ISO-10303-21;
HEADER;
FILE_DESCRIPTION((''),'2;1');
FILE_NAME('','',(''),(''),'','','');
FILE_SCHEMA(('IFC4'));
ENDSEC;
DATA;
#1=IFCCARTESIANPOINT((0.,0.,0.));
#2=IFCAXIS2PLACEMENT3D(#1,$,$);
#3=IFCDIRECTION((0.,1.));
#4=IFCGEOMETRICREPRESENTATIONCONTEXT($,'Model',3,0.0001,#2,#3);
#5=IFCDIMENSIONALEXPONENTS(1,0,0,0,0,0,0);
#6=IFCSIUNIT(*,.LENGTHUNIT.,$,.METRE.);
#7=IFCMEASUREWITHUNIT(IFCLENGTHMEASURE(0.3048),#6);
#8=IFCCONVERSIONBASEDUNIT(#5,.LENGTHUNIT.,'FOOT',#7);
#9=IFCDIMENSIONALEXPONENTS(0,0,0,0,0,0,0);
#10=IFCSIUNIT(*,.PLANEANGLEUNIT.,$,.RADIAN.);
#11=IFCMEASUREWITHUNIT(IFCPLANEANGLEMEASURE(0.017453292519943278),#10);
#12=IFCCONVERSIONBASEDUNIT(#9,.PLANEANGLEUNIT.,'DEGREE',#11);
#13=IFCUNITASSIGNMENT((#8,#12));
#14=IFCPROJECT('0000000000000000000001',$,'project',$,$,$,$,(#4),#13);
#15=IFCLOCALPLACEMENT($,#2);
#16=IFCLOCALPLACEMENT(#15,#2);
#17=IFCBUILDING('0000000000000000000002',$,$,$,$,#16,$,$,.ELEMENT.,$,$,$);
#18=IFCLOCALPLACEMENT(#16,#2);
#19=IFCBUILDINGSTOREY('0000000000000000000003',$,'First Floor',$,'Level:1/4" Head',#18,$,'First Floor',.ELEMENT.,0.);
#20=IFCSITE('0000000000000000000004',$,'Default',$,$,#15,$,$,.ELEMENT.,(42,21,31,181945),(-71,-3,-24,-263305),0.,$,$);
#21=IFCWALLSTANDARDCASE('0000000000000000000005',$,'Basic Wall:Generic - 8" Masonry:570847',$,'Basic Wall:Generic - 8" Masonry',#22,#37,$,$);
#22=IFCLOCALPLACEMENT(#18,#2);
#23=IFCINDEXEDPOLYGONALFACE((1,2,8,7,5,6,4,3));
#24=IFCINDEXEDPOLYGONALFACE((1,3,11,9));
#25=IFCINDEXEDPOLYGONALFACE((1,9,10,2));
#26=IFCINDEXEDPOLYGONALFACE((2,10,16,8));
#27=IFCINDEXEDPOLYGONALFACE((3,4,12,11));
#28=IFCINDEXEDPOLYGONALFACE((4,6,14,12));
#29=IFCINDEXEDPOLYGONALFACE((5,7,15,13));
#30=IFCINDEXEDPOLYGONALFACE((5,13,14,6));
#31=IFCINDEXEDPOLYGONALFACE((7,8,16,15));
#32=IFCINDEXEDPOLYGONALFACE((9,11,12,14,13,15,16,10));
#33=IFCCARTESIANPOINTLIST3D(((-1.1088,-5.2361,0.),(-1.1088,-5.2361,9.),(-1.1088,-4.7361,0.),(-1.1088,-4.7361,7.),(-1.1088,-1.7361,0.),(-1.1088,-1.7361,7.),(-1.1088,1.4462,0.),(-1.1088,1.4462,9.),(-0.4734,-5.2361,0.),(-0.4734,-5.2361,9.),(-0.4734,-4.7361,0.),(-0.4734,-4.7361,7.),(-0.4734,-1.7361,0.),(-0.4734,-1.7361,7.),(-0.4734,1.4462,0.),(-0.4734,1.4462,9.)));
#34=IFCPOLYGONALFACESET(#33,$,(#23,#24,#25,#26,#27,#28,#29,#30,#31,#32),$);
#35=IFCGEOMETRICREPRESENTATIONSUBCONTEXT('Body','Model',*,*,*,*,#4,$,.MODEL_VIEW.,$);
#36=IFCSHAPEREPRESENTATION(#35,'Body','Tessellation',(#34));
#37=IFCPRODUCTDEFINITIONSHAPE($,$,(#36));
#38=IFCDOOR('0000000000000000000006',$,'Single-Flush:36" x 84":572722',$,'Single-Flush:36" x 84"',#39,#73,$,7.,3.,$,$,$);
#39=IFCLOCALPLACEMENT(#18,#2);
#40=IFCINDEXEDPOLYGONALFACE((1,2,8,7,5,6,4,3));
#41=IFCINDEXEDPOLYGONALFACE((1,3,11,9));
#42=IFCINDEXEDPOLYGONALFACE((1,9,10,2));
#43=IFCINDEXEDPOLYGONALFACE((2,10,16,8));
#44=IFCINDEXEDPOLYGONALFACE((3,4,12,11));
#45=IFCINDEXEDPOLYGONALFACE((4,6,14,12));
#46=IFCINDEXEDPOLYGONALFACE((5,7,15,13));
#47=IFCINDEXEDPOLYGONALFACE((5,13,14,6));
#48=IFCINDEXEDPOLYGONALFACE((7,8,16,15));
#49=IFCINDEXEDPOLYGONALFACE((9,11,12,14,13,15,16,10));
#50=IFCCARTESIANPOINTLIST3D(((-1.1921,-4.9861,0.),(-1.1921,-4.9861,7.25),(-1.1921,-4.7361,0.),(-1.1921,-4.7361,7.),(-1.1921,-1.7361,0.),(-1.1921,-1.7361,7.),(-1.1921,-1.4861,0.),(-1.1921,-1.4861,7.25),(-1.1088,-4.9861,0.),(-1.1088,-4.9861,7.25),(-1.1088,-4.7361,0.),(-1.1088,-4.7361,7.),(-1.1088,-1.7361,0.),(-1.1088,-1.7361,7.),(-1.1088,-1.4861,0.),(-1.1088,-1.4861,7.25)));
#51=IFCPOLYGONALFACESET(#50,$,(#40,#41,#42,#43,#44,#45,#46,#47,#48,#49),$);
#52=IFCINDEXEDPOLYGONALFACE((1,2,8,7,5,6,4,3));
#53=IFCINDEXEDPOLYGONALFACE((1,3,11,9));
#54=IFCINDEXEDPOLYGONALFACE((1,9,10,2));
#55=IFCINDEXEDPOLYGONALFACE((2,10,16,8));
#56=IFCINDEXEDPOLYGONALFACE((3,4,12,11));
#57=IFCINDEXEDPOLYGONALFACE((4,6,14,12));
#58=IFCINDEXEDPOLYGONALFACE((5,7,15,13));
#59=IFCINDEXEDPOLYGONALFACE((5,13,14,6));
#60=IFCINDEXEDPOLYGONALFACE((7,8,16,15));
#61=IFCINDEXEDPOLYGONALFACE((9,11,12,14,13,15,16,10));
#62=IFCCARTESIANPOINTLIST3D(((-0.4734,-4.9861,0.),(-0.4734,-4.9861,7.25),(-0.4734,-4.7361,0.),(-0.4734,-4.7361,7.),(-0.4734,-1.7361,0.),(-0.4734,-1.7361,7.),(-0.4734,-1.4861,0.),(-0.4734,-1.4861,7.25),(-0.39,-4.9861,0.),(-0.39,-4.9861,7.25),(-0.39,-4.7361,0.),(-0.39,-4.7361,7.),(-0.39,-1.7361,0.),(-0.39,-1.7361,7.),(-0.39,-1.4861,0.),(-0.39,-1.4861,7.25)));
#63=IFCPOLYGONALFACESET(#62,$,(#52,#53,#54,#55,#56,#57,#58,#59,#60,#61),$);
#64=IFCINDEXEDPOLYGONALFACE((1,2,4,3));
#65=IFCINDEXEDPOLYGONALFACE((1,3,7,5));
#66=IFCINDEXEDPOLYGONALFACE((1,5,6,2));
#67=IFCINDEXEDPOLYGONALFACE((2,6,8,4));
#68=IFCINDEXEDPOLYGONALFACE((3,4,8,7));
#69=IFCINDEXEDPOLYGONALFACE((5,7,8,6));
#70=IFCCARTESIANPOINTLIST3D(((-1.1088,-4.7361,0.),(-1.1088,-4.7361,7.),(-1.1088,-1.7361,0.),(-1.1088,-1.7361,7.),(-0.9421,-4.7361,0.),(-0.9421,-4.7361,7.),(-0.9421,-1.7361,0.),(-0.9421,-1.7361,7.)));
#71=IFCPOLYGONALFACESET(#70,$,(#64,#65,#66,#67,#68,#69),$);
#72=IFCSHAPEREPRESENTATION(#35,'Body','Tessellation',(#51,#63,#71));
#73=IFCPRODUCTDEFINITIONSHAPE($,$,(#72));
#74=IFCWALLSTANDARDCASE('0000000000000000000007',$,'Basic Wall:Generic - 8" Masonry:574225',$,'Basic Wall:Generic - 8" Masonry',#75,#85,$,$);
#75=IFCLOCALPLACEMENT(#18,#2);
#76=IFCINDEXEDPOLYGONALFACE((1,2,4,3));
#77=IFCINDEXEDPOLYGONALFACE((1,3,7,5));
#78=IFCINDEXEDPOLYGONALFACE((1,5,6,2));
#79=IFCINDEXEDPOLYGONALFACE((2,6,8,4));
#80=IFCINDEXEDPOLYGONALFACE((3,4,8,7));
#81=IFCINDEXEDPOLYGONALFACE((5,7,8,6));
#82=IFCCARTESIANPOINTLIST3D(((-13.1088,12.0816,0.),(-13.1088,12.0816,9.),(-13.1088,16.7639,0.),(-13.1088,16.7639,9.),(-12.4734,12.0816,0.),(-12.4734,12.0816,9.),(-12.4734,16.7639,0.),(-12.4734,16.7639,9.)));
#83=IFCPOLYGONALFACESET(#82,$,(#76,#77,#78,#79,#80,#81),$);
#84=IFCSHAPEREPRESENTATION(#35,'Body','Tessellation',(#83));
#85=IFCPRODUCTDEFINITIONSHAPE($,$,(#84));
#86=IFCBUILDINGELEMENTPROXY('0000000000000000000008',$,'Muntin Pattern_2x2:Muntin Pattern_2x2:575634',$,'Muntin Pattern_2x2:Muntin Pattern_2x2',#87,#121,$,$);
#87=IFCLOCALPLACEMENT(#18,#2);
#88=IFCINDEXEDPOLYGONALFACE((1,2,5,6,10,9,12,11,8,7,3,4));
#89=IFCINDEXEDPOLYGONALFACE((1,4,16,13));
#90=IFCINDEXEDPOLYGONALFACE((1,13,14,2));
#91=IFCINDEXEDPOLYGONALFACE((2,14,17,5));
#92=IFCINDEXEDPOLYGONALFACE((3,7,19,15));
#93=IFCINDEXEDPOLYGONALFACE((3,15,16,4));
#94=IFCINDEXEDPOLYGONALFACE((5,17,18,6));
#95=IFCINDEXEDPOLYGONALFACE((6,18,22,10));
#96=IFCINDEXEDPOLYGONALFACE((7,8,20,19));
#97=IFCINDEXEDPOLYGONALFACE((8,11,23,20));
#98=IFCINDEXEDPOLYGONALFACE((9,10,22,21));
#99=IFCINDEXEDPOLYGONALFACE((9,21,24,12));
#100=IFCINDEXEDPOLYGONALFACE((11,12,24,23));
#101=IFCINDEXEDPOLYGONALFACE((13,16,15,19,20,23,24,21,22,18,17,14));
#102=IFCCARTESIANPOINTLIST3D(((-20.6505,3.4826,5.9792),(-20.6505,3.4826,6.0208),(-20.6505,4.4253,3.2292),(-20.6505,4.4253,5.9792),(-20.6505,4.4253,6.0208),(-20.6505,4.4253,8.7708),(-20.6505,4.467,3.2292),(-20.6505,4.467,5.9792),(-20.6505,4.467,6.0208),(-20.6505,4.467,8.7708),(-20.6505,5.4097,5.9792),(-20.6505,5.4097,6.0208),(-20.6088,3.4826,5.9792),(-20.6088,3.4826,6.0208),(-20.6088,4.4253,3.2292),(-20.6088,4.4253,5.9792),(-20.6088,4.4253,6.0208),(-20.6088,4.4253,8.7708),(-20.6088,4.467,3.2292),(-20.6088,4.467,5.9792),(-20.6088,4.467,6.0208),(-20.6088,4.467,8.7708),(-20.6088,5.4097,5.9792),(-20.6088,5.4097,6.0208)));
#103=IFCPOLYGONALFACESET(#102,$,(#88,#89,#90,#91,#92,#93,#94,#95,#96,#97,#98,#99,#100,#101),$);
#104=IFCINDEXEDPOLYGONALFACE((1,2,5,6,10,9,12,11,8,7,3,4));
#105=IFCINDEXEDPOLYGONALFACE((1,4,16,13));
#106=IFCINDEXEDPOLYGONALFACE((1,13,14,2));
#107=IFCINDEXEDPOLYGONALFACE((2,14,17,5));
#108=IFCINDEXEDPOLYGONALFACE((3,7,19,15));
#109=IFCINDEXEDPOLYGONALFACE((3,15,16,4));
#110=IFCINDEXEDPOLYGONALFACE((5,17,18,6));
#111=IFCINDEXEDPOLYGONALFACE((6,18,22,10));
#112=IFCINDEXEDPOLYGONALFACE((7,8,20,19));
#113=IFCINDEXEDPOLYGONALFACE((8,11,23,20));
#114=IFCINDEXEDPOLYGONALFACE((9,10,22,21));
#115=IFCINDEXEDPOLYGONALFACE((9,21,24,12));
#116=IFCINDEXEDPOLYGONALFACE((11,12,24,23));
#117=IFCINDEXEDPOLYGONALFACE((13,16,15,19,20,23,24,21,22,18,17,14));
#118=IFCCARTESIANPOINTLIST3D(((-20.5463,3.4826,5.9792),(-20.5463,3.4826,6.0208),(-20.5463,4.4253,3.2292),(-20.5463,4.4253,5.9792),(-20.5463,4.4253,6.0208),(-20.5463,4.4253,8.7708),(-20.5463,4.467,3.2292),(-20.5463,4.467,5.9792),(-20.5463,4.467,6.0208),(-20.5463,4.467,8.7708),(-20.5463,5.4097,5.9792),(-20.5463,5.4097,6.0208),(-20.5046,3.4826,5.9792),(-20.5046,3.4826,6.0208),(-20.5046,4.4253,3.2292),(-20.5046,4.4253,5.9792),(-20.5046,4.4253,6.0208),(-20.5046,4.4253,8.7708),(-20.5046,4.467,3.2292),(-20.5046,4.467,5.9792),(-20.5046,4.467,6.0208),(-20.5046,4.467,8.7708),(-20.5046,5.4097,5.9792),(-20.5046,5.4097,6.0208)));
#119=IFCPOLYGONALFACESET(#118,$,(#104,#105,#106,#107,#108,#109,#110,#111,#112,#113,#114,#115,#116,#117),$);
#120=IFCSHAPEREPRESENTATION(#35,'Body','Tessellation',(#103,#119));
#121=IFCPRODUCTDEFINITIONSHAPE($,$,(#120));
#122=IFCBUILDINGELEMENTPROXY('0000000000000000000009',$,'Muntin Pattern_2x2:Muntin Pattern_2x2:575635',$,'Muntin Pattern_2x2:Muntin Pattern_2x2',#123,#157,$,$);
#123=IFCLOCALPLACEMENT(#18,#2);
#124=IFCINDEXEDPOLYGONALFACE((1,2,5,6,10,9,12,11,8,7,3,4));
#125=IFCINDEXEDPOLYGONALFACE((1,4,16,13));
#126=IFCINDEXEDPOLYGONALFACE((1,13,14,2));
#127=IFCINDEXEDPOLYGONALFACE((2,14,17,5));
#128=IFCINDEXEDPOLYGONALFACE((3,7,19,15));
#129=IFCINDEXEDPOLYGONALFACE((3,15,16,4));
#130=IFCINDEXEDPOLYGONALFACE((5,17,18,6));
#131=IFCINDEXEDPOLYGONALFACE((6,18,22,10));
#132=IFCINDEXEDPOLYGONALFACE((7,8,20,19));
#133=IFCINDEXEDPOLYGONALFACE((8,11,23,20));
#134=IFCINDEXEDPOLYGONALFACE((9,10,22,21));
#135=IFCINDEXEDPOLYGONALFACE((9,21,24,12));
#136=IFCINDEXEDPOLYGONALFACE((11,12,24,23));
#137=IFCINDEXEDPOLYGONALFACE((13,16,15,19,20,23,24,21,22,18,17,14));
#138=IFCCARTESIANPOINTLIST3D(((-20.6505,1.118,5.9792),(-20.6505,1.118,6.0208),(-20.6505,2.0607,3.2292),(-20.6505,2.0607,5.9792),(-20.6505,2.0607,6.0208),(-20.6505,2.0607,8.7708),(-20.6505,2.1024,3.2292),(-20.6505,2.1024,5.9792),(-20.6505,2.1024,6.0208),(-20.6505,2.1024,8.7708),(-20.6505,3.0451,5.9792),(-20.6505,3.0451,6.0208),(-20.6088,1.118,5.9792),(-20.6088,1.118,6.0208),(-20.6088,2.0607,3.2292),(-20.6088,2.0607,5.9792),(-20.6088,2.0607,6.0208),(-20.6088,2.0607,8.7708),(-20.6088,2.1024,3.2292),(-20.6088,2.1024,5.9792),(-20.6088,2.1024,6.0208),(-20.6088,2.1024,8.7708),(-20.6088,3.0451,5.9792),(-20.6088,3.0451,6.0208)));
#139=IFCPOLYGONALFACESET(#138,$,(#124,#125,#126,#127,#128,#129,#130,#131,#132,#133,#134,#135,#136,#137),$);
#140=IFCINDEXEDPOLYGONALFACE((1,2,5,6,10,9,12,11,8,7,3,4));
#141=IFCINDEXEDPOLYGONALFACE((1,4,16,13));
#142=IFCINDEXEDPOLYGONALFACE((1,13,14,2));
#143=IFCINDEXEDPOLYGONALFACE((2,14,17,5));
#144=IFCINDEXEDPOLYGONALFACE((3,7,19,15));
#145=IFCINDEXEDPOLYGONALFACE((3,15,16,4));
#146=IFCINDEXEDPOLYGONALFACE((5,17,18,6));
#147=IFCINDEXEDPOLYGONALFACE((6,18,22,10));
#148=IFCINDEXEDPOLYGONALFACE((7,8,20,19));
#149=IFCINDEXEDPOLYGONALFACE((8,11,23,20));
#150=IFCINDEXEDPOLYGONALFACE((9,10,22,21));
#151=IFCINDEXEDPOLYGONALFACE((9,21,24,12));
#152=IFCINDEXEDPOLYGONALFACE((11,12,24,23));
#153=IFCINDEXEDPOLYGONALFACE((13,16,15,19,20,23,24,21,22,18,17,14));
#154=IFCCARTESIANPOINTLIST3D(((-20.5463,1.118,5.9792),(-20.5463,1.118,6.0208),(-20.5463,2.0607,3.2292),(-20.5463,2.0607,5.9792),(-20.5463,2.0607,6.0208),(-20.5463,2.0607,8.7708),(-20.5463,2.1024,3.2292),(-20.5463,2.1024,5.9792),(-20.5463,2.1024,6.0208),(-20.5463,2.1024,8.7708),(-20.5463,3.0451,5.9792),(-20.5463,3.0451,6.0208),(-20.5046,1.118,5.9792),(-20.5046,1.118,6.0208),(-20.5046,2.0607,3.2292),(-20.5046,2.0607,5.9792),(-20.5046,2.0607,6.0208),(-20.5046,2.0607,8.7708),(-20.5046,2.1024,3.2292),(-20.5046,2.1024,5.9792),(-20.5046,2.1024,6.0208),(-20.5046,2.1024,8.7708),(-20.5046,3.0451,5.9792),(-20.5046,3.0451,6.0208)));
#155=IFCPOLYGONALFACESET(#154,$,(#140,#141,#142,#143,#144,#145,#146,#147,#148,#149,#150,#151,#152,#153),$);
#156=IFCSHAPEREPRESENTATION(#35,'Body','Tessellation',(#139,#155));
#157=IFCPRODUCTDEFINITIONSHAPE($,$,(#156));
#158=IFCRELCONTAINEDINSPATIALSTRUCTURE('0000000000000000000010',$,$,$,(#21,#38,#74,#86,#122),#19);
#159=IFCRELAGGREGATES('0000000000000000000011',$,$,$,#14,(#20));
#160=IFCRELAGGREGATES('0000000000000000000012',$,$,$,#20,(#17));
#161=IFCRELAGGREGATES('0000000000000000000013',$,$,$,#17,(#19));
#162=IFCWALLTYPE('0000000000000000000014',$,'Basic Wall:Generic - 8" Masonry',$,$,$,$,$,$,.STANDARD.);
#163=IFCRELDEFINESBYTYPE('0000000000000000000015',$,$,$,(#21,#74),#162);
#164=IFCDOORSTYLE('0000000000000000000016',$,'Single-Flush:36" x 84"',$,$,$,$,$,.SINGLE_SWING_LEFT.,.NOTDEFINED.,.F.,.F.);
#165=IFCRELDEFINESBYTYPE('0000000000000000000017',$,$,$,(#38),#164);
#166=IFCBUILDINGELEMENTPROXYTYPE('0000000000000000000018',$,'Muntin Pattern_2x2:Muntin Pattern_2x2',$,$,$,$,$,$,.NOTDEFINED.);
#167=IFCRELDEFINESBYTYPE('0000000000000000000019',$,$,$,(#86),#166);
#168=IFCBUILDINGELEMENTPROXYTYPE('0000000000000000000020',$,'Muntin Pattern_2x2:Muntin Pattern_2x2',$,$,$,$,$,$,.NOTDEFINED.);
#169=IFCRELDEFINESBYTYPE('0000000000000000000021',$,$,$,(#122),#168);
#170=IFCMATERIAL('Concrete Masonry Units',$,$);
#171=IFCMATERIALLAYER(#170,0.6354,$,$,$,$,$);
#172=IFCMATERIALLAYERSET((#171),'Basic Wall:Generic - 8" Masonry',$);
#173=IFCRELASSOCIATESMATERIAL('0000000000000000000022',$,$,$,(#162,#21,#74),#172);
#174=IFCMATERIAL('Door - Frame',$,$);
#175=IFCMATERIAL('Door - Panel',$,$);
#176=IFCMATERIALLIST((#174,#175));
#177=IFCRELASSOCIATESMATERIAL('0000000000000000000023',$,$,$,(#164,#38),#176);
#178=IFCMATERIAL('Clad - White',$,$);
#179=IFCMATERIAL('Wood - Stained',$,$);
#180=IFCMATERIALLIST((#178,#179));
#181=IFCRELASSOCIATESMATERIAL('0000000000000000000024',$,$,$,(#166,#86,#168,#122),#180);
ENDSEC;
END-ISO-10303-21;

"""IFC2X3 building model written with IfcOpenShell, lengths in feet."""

from ifc_helpers import new_model, entity, si_unit, converted_unit, direction, frame, frame_2d, origin, place, context, subcontext, project, spatial, polyline, rectangle, outline, extrude, source, transform, mapped, material, material_list, layer, layer_set, layer_usage, type_object, type_shapes, element, fill, save


model = new_model("IFC2X3")

# Units and contexts
model_context = context("Model", 3, precision=0.0001, world=origin(), true_north=direction((0.0, 1.0)))
body_context = subcontext(model_context, "Body", "Model", "MODEL_VIEW")
ifc_project = project(units=[converted_unit("LENGTHUNIT", "FOOT", entity("IfcLengthMeasure", 0.3048), si_unit("LENGTHUNIT", "METRE"), dimensions=[1, 0, 0, 0, 0, 0, 0]), converted_unit("PLANEANGLEUNIT", "DEGREE", entity("IfcPlaneAngleMeasure", 0.017453292519943278), si_unit("PLANEANGLEUNIT", "RADIAN"), dimensions=[0, 0, 0, 0, 0, 0, 0])], contexts=[model_context])

# Site, building, storey
site_placement = place(None, origin())
site = spatial("IfcSite", under=ifc_project, at=site_placement, Name="Default", CompositionType="ELEMENT", RefLatitude=(42, 21, 31, 181945), RefLongitude=(-71, -3, -24, -263305), RefElevation=0.0)
building_placement = place(site_placement, origin())
building = spatial("IfcBuilding", under=site, at=building_placement, CompositionType="ELEMENT")
storey_placement = place(building_placement, origin())
storey = spatial("IfcBuildingStorey", under=building, at=storey_placement, Name="First Floor", ObjectType="Level:1/4\" Head", LongName="First Floor", CompositionType="ELEMENT", Elevation=0.0)

# Shared definitions
ifc_material_1 = material(Name="Concrete Masonry Units")
ifc_layer_1 = layer(ifc_material_1, 0.6354)
ifc_layer_set_1 = layer_set([ifc_layer_1], Name="Basic Wall:Generic - 8\" Masonry")
wall_type = type_object("IfcWallType", Name="Basic Wall:Generic - 8\" Masonry", PredefinedType="STANDARD", material=ifc_layer_set_1)

# Shared definitions
ifc_material_2 = material(Name="Door - Frame")
ifc_material_3 = material(Name="Door - Panel")
ifc_material_list_1 = material_list([ifc_material_2, ifc_material_3])

# Wall, opening, door
ifc_layer_usage_1 = layer_usage(ifc_layer_set_1, "AXIS2", "NEGATIVE", 0.3177)
wall_1_placement = place(storey_placement, frame((-0.7911, 1.4462, 0.0), z_axis=(0.0, 0.0, 1.0), x_axis=(0.0, -1.0, 0.0)))
wall_1 = element("IfcWallStandardCase", 1, at=wall_1_placement, inside=storey, type_object=wall_type, material=ifc_layer_usage_1, Name="Basic Wall:Generic - 8\" Masonry:570847", ObjectType="Basic Wall:Generic - 8\" Masonry", context=body_context, shape_type="SweptSolid", body=[
    extrude(rectangle(XDim=6.6823, YDim=0.6354, at=frame_2d((3.3411, 0.0), x_axis=(1.0, 0.0))), origin(), (0.0, 0.0, 1.0), 9.0),
])
opening_1_placement = place(wall_1_placement, frame((6.1823, 0.3177, 0.0)))
opening_1 = element("IfcOpeningElement", 2, at=opening_1_placement, cuts=wall_1, ObjectType="Opening", context=body_context, shape_type="SweptSolid", body=[
    extrude(rectangle(XDim=3.0, YDim=7.0, at=frame_2d((3.5, 1.5), x_axis=(0.0, -1.0))), frame((0.0, 0.0, 0.0), z_axis=(0.0, -1.0, 0.0), x_axis=(0.0, 0.0, 1.0)), (0.0, 0.0, 1.0), 0.6354),
])
door_style_1 = type_object("IfcDoorStyle", Name="Single-Flush:36\" x 84\"", ConstructionType="NOTDEFINED", OperationType="SINGLE_SWING_LEFT", ParameterTakesPrecedence=False, Sizeable=False, material=ifc_material_list_1)
shared_shape_1 = source(origin(), body_context, "Body", "SweptSolid", [
    extrude(outline(polyline([(-1.75, -3.6875), (1.75, -3.6875), (1.75, 3.5625), (1.5, 3.5625), (1.5, -3.4375), (-1.5, -3.4375), (-1.5, 3.5625), (-1.75, 3.5625), (-1.75, -3.6875)])), frame((1.5, 0.7187, 3.5625), z_axis=(0.0, -1.0, 0.0), x_axis=(-1.0, 0.0, 0.0)), (0.0, 0.0, 1.0), 0.0833),
    extrude(outline(polyline([(-3.6875, -1.75), (3.5625, -1.75), (3.5625, -1.5), (-3.4375, -1.5), (-3.4375, 1.5), (3.5625, 1.5), (3.5625, 1.75), (-3.6875, 1.75), (-3.6875, -1.75)])), frame((1.5, 0.0, 3.5625), z_axis=(0.0, -1.0, 0.0), x_axis=(0.0, 0.0, -1.0)), (0.0, 0.0, 1.0), 0.0833),
    extrude(rectangle(XDim=3.0, YDim=0.1667, at=frame_2d((0.0, 0.0), x_axis=(1.0, 0.0))), frame((1.5, 0.5521, 0.0)), (0.0, 0.0, 1.0), 7.0),
])
type_shapes(door_style_1, [shared_shape_1])
door_1_placement = place(opening_1_placement, frame((0.0, 0.0, 0.0), z_axis=(0.0, 0.0, 1.0), x_axis=(-1.0, 0.0, 0.0)))
door_1 = element("IfcDoor", 3, at=door_1_placement, inside=storey, type_object=door_style_1, material=ifc_material_list_1, Name="Single-Flush:36\" x 84\":572722", ObjectType="Single-Flush:36\" x 84\"", OverallHeight=7.0, OverallWidth=3.0, context=body_context, shape_type="MappedRepresentation", body=[
    mapped(shared_shape_1, transform((0.0, 0.0, 0.0), scale=1.0)),
])
fill(opening_1, door_1)

# Wall
ifc_layer_usage_2 = layer_usage(ifc_layer_set_1, "AXIS2", "NEGATIVE", 0.3177)
wall_2_placement = place(storey_placement, frame((-12.7911, 12.0816, 0.0), z_axis=(0.0, 0.0, 1.0), x_axis=(0.0, 1.0, 0.0)))
element("IfcWallStandardCase", 4, at=wall_2_placement, inside=storey, type_object=wall_type, material=ifc_layer_usage_2, Name="Basic Wall:Generic - 8\" Masonry:574225", ObjectType="Basic Wall:Generic - 8\" Masonry", context=body_context, shape_type="SweptSolid", body=[
    extrude(rectangle(XDim=4.6823, YDim=0.6354, at=frame_2d((2.3411, 0.0), x_axis=(-1.0, 0.0))), origin(), (0.0, 0.0, 1.0), 9.0),
])

# Building element proxies
ifc_material_4 = material(Name="Clad - White")
ifc_material_5 = material(Name="Wood - Stained")
ifc_material_list_2 = material_list([ifc_material_4, ifc_material_5])
building_element_proxy_type_1 = type_object("IfcBuildingElementProxyType", Name="Muntin Pattern_2x2:Muntin Pattern_2x2", PredefinedType="NOTDEFINED", material=ifc_material_list_2)
shared_shape_2 = source(origin(), body_context, "Body", "SweptSolid", [
    extrude(outline(polyline([(0.0208, -0.0208), (2.7708, -0.0208), (2.7708, 0.0208), (0.0208, 0.0208), (0.0208, 0.9635), (-0.0208, 0.9635), (-0.0208, 0.0208), (-2.7708, 0.0208), (-2.7708, -0.0208), (-0.0208, -0.0208), (-0.0208, -0.9635), (0.0208, -0.9635), (0.0208, -0.0208)])), frame((0.0, -0.0729, 2.7708), z_axis=(0.0, 1.0, 0.0), x_axis=(0.0, 0.0, 1.0)), (0.0, 0.0, 1.0), 0.0417),
    extrude(outline(polyline([(0.0208, -0.0208), (2.7708, -0.0208), (2.7708, 0.0208), (0.0208, 0.0208), (0.0208, 0.9635), (-0.0208, 0.9635), (-0.0208, 0.0208), (-2.7708, 0.0208), (-2.7708, -0.0208), (-0.0208, -0.0208), (-0.0208, -0.9635), (0.0208, -0.9635), (0.0208, -0.0208)])), frame((0.0, 0.0313, 2.7708), z_axis=(0.0, 1.0, 0.0), x_axis=(0.0, 0.0, 1.0)), (0.0, 0.0, 1.0), 0.0417),
])
type_shapes(building_element_proxy_type_1, [shared_shape_2])
proxy_1_placement = place(storey_placement, frame((-20.5775, 4.4462, 3.2292), z_axis=(0.0, 0.0, 1.0), x_axis=(0.0, -1.0, 0.0)))
element("IfcBuildingElementProxy", 5, at=proxy_1_placement, inside=storey, type_object=building_element_proxy_type_1, material=ifc_material_list_2, Name="Muntin Pattern_2x2:Muntin Pattern_2x2:575634", ObjectType="Muntin Pattern_2x2:Muntin Pattern_2x2", context=body_context, shape_type="MappedRepresentation", body=[
    mapped(shared_shape_2, transform((0.0, 0.0, 0.0), scale=1.0)),
])
building_element_proxy_type_2 = type_object("IfcBuildingElementProxyType", Name="Muntin Pattern_2x2:Muntin Pattern_2x2", PredefinedType="NOTDEFINED", material=ifc_material_list_2)
shared_shape_3 = source(origin(), body_context, "Body", "SweptSolid", [
    extrude(outline(polyline([(0.0208, -0.0208), (2.7708, -0.0208), (2.7708, 0.0208), (0.0208, 0.0208), (0.0208, 0.9635), (-0.0208, 0.9635), (-0.0208, 0.0208), (-2.7708, 0.0208), (-2.7708, -0.0208), (-0.0208, -0.0208), (-0.0208, -0.9635), (0.0208, -0.9635), (0.0208, -0.0208)])), frame((0.0, 0.0313, 2.7708), z_axis=(0.0, 1.0, 0.0), x_axis=(0.0, 0.0, 1.0)), (0.0, 0.0, 1.0), 0.0417),
    extrude(outline(polyline([(0.0208, -0.0208), (2.7708, -0.0208), (2.7708, 0.0208), (0.0208, 0.0208), (0.0208, 0.9635), (-0.0208, 0.9635), (-0.0208, 0.0208), (-2.7708, 0.0208), (-2.7708, -0.0208), (-0.0208, -0.0208), (-0.0208, -0.9635), (0.0208, -0.9635), (0.0208, -0.0208)])), frame((0.0, -0.0729, 2.7708), z_axis=(0.0, 1.0, 0.0), x_axis=(0.0, 0.0, 1.0)), (0.0, 0.0, 1.0), 0.0417),
])
type_shapes(building_element_proxy_type_2, [shared_shape_3])
proxy_2_placement = place(storey_placement, frame((-20.5775, 2.0816, 3.2292), z_axis=(0.0, 0.0, 1.0), x_axis=(0.0, 1.0, 0.0)))
element("IfcBuildingElementProxy", 6, at=proxy_2_placement, inside=storey, type_object=building_element_proxy_type_2, material=ifc_material_list_2, Name="Muntin Pattern_2x2:Muntin Pattern_2x2:575635", ObjectType="Muntin Pattern_2x2:Muntin Pattern_2x2", context=body_context, shape_type="MappedRepresentation", body=[
    mapped(shared_shape_3, transform((0.0, 0.0, 0.0), scale=1.0)),
])

save(model, "model.ifc")
